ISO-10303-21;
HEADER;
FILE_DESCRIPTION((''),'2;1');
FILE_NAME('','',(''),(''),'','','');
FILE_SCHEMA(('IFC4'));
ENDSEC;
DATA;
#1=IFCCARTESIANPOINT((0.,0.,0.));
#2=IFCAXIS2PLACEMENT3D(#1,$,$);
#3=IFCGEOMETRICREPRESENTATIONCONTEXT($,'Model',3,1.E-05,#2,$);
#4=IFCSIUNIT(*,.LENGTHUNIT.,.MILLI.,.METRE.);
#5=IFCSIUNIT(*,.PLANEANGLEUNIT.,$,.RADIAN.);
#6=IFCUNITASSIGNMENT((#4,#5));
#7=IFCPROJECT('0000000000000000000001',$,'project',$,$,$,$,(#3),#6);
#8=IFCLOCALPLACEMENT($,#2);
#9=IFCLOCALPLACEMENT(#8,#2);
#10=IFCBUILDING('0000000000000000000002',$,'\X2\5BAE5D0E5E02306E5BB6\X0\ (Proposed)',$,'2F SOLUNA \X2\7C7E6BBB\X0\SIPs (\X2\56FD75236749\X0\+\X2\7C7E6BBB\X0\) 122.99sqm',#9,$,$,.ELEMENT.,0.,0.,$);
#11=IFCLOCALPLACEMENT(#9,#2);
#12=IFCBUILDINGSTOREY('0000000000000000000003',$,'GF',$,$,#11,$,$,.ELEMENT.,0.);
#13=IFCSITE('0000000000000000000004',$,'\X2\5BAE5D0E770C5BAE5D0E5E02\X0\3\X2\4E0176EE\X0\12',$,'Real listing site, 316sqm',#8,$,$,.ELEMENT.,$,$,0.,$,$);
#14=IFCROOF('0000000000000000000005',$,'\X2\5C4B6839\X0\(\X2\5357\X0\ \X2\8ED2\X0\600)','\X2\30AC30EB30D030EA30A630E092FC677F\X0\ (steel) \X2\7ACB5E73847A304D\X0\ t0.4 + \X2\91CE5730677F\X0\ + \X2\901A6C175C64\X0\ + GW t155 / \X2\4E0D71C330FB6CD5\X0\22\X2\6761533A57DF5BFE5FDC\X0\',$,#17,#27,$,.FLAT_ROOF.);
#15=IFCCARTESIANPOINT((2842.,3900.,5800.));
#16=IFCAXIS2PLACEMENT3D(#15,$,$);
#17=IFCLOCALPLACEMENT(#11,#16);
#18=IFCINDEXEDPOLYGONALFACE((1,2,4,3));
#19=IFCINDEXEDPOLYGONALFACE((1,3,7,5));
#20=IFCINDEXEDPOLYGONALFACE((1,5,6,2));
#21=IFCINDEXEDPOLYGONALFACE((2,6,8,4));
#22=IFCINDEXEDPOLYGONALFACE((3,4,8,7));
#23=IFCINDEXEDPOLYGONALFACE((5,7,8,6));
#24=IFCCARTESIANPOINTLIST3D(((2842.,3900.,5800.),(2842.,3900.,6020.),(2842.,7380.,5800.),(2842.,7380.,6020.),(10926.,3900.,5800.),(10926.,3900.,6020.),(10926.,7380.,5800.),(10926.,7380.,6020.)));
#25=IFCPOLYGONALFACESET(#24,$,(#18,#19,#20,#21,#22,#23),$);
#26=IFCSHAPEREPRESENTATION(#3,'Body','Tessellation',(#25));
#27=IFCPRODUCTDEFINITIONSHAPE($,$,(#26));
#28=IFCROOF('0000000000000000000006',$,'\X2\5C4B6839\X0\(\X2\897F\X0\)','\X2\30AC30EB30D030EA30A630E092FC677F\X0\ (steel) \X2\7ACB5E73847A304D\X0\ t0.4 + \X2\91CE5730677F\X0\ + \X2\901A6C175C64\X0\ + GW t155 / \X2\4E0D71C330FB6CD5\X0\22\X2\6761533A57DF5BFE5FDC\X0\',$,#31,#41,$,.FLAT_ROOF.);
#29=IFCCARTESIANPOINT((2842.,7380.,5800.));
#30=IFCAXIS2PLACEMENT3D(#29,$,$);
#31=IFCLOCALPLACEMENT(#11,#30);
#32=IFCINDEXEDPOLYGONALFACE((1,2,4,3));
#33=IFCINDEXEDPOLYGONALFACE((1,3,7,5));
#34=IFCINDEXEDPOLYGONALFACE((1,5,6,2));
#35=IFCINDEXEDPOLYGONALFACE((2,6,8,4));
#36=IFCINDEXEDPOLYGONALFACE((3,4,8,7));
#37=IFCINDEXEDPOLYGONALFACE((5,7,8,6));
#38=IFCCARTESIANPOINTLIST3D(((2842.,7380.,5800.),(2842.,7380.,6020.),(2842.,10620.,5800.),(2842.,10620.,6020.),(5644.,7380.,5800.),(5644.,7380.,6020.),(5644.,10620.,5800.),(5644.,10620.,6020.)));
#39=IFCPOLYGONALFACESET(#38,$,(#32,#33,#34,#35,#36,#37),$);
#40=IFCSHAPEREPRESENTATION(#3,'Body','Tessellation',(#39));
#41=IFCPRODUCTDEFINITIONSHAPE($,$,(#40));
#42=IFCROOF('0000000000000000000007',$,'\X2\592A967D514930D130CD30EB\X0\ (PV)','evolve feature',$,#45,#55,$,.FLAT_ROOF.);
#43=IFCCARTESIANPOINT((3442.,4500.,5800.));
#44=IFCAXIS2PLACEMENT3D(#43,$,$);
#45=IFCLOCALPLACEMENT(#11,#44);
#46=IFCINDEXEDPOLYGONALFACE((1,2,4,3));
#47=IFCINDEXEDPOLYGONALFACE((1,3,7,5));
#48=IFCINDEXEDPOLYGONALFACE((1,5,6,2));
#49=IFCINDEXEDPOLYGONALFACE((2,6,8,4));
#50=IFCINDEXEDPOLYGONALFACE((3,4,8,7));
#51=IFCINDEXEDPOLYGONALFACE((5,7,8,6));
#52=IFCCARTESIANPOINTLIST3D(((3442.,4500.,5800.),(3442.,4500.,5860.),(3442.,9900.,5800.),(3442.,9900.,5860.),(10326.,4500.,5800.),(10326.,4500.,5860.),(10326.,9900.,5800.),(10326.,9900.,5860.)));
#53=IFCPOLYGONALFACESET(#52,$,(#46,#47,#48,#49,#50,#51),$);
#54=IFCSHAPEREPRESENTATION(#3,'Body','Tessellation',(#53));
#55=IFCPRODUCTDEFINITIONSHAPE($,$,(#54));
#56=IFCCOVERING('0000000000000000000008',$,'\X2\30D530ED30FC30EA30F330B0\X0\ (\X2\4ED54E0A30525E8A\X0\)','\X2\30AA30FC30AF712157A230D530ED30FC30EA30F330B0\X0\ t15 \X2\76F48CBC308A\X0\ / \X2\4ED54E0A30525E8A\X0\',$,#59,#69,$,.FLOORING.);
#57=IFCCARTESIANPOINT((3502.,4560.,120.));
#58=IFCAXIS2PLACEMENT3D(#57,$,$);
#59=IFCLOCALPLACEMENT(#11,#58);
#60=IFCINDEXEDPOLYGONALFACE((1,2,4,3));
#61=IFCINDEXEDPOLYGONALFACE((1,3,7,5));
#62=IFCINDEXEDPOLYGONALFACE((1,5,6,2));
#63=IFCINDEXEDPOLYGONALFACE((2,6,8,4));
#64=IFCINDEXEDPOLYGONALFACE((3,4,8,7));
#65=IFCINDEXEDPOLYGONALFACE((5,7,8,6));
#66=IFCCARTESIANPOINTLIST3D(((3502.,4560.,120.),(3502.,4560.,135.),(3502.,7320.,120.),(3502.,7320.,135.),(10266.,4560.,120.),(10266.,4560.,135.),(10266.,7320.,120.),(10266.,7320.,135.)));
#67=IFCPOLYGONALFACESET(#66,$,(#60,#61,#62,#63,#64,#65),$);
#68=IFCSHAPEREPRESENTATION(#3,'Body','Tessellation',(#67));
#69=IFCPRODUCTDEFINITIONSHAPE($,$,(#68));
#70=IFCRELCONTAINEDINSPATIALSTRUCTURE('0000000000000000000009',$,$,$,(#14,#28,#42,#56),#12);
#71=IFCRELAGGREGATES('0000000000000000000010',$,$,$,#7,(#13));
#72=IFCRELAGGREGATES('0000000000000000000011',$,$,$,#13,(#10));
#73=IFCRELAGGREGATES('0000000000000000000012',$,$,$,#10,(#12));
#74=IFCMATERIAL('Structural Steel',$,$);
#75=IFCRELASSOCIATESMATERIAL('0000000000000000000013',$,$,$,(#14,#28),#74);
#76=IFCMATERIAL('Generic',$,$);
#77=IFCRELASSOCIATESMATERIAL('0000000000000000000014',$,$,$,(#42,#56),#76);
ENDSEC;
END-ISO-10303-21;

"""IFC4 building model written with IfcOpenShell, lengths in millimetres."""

from ifc_helpers import new_model, si_unit, frame, frame_2d, origin, place, context, project, spatial, rectangle, extrude, material, element, save


model = new_model("IFC4")

# Units and contexts
model_context = context("Model", 3, precision=1e-05, world=origin())
ifc_project = project(units=[si_unit("LENGTHUNIT", "METRE", prefix="MILLI"), si_unit("PLANEANGLEUNIT", "RADIAN")], contexts=[model_context])

# Site, building, storey
site_placement = place(None, origin())
site = spatial("IfcSite", under=ifc_project, at=site_placement, Name="宮崎県宮崎市3丁目12", ObjectType="Real listing site, 316sqm", CompositionType="ELEMENT", RefElevation=0.0)
building_placement = place(site_placement, origin())
building = spatial("IfcBuilding", under=site, at=building_placement, Name="宮崎市の家 (Proposed)", ObjectType="2F SOLUNA 籾殻SIPs (国産杉+籾殻) 122.99sqm", CompositionType="ELEMENT", ElevationOfRefHeight=0.0, ElevationOfTerrain=0.0)
storey_placement = place(building_placement, origin())
storey = spatial("IfcBuildingStorey", under=building, at=storey_placement, Name="GF", CompositionType="ELEMENT", Elevation=0.0)

# Shared definitions
ifc_material_1 = material(Name="Generic")

# Roofs
ifc_material_2 = material(Name="Structural Steel")
roof_1_placement = place(storey_placement, frame((2842.0, 3900.0, 5800.0)))
element("IfcRoof", 1, at=roof_1_placement, inside=storey, material=ifc_material_2, Name="屋根(南 軒600)", Description="ガルバリウム鋼板 (steel) 立平葺き t0.4 + 野地板 + 通気層 + GW t155 / 不燃・法22条区域対応", PredefinedType="FLAT_ROOF", context=model_context, shape_type="SweptSolid", body=[
    extrude(rectangle(XDim=8084.0, YDim=3480.0, at=frame_2d((4042.0, 1740.0))), frame((2842.0, 3900.0, 5800.0)), (0.0, 0.0, 1.0), 220.0),
])
roof_2_placement = place(storey_placement, frame((2842.0, 7380.0, 5800.0)))
element("IfcRoof", 2, at=roof_2_placement, inside=storey, material=ifc_material_2, Name="屋根(西)", Description="ガルバリウム鋼板 (steel) 立平葺き t0.4 + 野地板 + 通気層 + GW t155 / 不燃・法22条区域対応", PredefinedType="FLAT_ROOF", context=model_context, shape_type="SweptSolid", body=[
    extrude(rectangle(XDim=2802.0, YDim=3240.0, at=frame_2d((1401.0, 1620.0))), frame((2842.0, 7380.0, 5800.0)), (0.0, 0.0, 1.0), 220.0),
])
roof_3_placement = place(storey_placement, frame((3442.0, 4500.0, 5800.0)))
element("IfcRoof", 3, at=roof_3_placement, inside=storey, material=ifc_material_1, Name="太陽光パネル (PV)", Description="evolve feature", PredefinedType="FLAT_ROOF", context=model_context, shape_type="SweptSolid", body=[
    extrude(rectangle(XDim=6884.0, YDim=5400.0, at=frame_2d((3442.0, 2700.0))), frame((3442.0, 4500.0, 5800.0)), (0.0, 0.0, 1.0), 60.0),
])

# Covering
covering_placement = place(storey_placement, frame((3502.0, 4560.0, 120.0)))
element("IfcCovering", 4, at=covering_placement, inside=storey, material=ifc_material_1, Name="フローリング (仕上げ床)", Description="オーク無垢フローリング t15 直貼り / 仕上げ床", PredefinedType="FLOORING", context=model_context, shape_type="SweptSolid", body=[
    extrude(rectangle(XDim=6764.0, YDim=2760.0, at=frame_2d((3382.0, 1380.0))), frame((3502.0, 4560.0, 120.0)), (0.0, 0.0, 1.0), 15.0),
])

save(model, "model.ifc")
